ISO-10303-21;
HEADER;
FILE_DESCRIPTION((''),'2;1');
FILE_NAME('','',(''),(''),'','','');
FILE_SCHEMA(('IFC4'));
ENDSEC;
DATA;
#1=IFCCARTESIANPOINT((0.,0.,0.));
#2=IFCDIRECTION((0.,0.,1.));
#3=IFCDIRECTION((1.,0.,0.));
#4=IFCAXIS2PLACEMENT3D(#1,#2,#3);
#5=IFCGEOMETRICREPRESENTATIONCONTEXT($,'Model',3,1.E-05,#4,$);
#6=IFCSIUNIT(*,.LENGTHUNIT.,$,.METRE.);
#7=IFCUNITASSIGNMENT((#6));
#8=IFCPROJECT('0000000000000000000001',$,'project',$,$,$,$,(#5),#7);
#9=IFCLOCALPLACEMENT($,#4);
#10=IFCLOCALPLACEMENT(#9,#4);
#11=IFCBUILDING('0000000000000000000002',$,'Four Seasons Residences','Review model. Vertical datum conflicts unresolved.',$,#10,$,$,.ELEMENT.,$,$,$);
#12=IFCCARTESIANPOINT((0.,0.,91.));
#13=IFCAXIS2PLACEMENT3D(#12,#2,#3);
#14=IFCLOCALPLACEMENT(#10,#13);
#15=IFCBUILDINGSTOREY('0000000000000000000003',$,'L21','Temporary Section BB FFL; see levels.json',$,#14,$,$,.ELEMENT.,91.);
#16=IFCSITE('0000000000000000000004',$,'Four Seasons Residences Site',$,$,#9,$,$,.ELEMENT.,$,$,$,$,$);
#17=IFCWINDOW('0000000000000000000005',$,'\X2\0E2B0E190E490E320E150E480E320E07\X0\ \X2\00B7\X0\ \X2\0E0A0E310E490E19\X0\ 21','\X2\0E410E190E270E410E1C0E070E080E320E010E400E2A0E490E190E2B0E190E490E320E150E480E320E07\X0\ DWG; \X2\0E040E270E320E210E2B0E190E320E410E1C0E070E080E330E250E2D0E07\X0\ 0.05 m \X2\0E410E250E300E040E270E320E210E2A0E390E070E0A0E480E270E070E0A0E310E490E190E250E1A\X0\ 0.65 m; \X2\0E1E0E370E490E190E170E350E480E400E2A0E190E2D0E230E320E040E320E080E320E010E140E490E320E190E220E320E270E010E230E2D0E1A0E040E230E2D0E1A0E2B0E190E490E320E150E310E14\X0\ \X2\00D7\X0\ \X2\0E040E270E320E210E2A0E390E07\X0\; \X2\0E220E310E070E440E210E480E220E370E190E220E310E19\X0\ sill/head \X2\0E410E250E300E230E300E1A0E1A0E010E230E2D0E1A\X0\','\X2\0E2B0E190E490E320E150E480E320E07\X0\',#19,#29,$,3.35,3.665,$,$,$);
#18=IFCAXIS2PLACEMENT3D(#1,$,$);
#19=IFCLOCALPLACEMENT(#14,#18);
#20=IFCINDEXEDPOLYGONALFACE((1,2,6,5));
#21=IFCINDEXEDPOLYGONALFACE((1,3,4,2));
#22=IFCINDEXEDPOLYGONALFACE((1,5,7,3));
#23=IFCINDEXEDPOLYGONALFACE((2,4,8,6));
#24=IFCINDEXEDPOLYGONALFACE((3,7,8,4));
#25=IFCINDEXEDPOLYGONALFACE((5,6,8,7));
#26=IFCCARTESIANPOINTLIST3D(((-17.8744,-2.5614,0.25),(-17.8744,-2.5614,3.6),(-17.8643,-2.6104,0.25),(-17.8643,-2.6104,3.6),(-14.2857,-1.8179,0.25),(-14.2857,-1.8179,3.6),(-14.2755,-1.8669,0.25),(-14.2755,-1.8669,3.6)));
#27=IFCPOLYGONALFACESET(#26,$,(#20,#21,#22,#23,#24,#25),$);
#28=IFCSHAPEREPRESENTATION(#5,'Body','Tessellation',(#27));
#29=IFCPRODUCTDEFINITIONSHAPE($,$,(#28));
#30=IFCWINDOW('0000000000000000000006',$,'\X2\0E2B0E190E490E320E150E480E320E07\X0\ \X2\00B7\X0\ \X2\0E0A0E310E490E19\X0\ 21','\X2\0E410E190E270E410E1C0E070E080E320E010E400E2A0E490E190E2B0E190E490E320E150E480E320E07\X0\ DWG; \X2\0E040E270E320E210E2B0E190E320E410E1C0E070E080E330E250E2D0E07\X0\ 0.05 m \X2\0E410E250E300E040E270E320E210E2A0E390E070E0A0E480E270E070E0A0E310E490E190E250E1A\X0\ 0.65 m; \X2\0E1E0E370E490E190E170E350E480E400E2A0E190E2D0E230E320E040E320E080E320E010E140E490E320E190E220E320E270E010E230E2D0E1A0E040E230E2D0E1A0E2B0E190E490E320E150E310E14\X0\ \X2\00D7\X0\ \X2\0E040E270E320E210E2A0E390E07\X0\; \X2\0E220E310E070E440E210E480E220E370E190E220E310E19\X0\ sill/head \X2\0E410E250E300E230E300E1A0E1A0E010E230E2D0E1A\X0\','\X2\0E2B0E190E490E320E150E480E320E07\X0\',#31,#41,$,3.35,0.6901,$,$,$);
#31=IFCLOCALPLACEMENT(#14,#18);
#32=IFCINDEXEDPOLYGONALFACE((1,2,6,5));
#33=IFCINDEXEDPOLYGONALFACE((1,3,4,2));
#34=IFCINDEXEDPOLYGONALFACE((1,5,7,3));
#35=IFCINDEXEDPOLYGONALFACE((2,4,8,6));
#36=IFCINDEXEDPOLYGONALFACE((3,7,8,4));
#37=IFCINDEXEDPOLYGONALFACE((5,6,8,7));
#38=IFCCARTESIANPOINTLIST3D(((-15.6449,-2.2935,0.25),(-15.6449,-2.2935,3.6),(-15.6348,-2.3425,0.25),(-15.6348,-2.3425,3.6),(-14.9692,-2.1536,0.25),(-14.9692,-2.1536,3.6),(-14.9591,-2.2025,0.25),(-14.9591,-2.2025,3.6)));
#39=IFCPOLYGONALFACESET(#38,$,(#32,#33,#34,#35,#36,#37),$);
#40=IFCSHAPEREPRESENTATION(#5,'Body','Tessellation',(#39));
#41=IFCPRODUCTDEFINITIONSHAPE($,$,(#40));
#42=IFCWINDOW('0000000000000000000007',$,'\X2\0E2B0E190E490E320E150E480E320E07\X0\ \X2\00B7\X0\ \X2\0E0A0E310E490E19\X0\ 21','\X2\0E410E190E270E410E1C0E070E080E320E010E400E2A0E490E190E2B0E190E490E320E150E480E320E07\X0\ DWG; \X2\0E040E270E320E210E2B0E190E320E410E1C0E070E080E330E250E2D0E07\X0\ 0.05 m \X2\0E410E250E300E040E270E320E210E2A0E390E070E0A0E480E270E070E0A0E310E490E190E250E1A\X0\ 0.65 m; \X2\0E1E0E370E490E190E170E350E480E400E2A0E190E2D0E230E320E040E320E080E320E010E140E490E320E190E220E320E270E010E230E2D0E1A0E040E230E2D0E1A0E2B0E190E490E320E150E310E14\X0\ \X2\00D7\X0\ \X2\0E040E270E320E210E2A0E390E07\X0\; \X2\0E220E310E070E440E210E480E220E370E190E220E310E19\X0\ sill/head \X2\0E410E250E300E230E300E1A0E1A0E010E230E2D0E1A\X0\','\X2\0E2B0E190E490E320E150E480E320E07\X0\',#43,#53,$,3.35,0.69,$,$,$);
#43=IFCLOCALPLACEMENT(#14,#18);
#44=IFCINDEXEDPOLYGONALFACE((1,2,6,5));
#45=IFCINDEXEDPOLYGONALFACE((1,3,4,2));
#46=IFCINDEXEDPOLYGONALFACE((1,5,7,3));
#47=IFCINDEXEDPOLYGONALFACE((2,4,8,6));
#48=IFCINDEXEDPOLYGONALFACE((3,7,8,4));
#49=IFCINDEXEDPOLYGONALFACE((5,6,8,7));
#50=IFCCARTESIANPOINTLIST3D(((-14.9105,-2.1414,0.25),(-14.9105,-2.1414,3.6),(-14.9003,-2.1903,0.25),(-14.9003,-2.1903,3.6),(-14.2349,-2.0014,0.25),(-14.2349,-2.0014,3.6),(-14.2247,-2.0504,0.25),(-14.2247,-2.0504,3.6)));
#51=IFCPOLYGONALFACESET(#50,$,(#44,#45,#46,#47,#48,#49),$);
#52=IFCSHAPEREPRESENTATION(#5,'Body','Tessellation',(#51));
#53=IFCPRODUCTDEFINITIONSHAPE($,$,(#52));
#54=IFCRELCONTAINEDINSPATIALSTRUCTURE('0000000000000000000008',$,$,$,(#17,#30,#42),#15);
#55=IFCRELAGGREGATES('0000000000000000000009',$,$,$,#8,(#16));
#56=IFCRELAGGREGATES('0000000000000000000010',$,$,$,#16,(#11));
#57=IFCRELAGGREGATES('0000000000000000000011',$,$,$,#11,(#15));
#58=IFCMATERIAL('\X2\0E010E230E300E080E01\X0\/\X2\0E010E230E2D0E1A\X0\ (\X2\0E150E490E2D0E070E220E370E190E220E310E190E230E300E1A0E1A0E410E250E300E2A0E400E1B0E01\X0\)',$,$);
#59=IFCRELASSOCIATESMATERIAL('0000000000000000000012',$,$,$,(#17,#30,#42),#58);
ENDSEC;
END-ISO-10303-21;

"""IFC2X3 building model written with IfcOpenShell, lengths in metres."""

from ifc_helpers import new_model, si_unit, frame, origin_with_axes, place, context, project, spatial, polyline, outline, extrude, material, element, save


model = new_model("IFC2X3")

# Units and contexts
model_context = context("Model", 3, precision=1e-05, world=origin_with_axes())
ifc_project = project(units=[si_unit("LENGTHUNIT", "METRE")], contexts=[model_context])

# Site, building, storey
site_placement = place(None, origin_with_axes())
site = spatial("IfcSite", under=ifc_project, at=site_placement, Name="Four Seasons Residences Site", CompositionType="ELEMENT")
building_placement = place(site_placement, origin_with_axes())
building = spatial("IfcBuilding", under=site, at=building_placement, Name="Four Seasons Residences", Description="Review model. Vertical datum conflicts unresolved.", CompositionType="ELEMENT")
storey_placement = place(building_placement, frame((0.0, 0.0, 91.0), z_axis=(0.0, 0.0, 1.0), x_axis=(1.0, 0.0, 0.0)))
storey = spatial("IfcBuildingStorey", under=building, at=storey_placement, Name="L21", Description="Temporary Section BB FFL; see levels.json", CompositionType="ELEMENT", Elevation=91.0)

# Windows
ifc_material = material(Name="กระจก/กรอบ (ต้องยืนยันระบบและสเปก)")
window_1_placement = place(storey_placement, origin_with_axes())
element("IfcWindow", 1, at=window_1_placement, inside=storey, material=ifc_material, Name="หน้าต่าง · ชั้น 21", Description="แนวแผงจากเส้นหน้าต่าง DWG; ความหนาแผงจำลอง 0.05 m และความสูงช่วงชั้นลบ 0.65 m; พื้นที่เสนอราคาจากด้านยาวกรอบครอบหน้าตัด × ความสูง; ยังไม่ยืนยัน sill/head และระบบกรอบ", ObjectType="หน้าต่าง", OverallHeight=3.35, OverallWidth=3.665, context=model_context, shape_type="SweptSolid", body=[
    extrude(outline(polyline([(-14.2857, -1.8179), (-14.2755, -1.8669), (-17.8643, -2.6104), (-17.8744, -2.5614), (-14.2857, -1.8179)])), frame((0.0, 0.0, 0.25), z_axis=(0.0, 0.0, 1.0), x_axis=(1.0, 0.0, 0.0)), (0.0, 0.0, 1.0), 3.35),
])
window_2_placement = place(storey_placement, origin_with_axes())
element("IfcWindow", 2, at=window_2_placement, inside=storey, material=ifc_material, Name="หน้าต่าง · ชั้น 21", Description="แนวแผงจากเส้นหน้าต่าง DWG; ความหนาแผงจำลอง 0.05 m และความสูงช่วงชั้นลบ 0.65 m; พื้นที่เสนอราคาจากด้านยาวกรอบครอบหน้าตัด × ความสูง; ยังไม่ยืนยัน sill/head และระบบกรอบ", ObjectType="หน้าต่าง", OverallHeight=3.35, OverallWidth=0.6901, context=model_context, shape_type="SweptSolid", body=[
    extrude(outline(polyline([(-14.9692, -2.1536), (-14.9591, -2.2025), (-15.6348, -2.3425), (-15.6449, -2.2935), (-14.9692, -2.1536)])), frame((0.0, 0.0, 0.25), z_axis=(0.0, 0.0, 1.0), x_axis=(1.0, 0.0, 0.0)), (0.0, 0.0, 1.0), 3.35),
])
window_3_placement = place(storey_placement, origin_with_axes())
element("IfcWindow", 3, at=window_3_placement, inside=storey, material=ifc_material, Name="หน้าต่าง · ชั้น 21", Description="แนวแผงจากเส้นหน้าต่าง DWG; ความหนาแผงจำลอง 0.05 m และความสูงช่วงชั้นลบ 0.65 m; พื้นที่เสนอราคาจากด้านยาวกรอบครอบหน้าตัด × ความสูง; ยังไม่ยืนยัน sill/head และระบบกรอบ", ObjectType="หน้าต่าง", OverallHeight=3.35, OverallWidth=0.69, context=model_context, shape_type="SweptSolid", body=[
    extrude(outline(polyline([(-14.2349, -2.0014), (-14.2247, -2.0504), (-14.9003, -2.1903), (-14.9105, -2.1414), (-14.2349, -2.0014)])), frame((0.0, 0.0, 0.25), z_axis=(0.0, 0.0, 1.0), x_axis=(1.0, 0.0, 0.0)), (0.0, 0.0, 1.0), 3.35),
])

save(model, "model.ifc")
